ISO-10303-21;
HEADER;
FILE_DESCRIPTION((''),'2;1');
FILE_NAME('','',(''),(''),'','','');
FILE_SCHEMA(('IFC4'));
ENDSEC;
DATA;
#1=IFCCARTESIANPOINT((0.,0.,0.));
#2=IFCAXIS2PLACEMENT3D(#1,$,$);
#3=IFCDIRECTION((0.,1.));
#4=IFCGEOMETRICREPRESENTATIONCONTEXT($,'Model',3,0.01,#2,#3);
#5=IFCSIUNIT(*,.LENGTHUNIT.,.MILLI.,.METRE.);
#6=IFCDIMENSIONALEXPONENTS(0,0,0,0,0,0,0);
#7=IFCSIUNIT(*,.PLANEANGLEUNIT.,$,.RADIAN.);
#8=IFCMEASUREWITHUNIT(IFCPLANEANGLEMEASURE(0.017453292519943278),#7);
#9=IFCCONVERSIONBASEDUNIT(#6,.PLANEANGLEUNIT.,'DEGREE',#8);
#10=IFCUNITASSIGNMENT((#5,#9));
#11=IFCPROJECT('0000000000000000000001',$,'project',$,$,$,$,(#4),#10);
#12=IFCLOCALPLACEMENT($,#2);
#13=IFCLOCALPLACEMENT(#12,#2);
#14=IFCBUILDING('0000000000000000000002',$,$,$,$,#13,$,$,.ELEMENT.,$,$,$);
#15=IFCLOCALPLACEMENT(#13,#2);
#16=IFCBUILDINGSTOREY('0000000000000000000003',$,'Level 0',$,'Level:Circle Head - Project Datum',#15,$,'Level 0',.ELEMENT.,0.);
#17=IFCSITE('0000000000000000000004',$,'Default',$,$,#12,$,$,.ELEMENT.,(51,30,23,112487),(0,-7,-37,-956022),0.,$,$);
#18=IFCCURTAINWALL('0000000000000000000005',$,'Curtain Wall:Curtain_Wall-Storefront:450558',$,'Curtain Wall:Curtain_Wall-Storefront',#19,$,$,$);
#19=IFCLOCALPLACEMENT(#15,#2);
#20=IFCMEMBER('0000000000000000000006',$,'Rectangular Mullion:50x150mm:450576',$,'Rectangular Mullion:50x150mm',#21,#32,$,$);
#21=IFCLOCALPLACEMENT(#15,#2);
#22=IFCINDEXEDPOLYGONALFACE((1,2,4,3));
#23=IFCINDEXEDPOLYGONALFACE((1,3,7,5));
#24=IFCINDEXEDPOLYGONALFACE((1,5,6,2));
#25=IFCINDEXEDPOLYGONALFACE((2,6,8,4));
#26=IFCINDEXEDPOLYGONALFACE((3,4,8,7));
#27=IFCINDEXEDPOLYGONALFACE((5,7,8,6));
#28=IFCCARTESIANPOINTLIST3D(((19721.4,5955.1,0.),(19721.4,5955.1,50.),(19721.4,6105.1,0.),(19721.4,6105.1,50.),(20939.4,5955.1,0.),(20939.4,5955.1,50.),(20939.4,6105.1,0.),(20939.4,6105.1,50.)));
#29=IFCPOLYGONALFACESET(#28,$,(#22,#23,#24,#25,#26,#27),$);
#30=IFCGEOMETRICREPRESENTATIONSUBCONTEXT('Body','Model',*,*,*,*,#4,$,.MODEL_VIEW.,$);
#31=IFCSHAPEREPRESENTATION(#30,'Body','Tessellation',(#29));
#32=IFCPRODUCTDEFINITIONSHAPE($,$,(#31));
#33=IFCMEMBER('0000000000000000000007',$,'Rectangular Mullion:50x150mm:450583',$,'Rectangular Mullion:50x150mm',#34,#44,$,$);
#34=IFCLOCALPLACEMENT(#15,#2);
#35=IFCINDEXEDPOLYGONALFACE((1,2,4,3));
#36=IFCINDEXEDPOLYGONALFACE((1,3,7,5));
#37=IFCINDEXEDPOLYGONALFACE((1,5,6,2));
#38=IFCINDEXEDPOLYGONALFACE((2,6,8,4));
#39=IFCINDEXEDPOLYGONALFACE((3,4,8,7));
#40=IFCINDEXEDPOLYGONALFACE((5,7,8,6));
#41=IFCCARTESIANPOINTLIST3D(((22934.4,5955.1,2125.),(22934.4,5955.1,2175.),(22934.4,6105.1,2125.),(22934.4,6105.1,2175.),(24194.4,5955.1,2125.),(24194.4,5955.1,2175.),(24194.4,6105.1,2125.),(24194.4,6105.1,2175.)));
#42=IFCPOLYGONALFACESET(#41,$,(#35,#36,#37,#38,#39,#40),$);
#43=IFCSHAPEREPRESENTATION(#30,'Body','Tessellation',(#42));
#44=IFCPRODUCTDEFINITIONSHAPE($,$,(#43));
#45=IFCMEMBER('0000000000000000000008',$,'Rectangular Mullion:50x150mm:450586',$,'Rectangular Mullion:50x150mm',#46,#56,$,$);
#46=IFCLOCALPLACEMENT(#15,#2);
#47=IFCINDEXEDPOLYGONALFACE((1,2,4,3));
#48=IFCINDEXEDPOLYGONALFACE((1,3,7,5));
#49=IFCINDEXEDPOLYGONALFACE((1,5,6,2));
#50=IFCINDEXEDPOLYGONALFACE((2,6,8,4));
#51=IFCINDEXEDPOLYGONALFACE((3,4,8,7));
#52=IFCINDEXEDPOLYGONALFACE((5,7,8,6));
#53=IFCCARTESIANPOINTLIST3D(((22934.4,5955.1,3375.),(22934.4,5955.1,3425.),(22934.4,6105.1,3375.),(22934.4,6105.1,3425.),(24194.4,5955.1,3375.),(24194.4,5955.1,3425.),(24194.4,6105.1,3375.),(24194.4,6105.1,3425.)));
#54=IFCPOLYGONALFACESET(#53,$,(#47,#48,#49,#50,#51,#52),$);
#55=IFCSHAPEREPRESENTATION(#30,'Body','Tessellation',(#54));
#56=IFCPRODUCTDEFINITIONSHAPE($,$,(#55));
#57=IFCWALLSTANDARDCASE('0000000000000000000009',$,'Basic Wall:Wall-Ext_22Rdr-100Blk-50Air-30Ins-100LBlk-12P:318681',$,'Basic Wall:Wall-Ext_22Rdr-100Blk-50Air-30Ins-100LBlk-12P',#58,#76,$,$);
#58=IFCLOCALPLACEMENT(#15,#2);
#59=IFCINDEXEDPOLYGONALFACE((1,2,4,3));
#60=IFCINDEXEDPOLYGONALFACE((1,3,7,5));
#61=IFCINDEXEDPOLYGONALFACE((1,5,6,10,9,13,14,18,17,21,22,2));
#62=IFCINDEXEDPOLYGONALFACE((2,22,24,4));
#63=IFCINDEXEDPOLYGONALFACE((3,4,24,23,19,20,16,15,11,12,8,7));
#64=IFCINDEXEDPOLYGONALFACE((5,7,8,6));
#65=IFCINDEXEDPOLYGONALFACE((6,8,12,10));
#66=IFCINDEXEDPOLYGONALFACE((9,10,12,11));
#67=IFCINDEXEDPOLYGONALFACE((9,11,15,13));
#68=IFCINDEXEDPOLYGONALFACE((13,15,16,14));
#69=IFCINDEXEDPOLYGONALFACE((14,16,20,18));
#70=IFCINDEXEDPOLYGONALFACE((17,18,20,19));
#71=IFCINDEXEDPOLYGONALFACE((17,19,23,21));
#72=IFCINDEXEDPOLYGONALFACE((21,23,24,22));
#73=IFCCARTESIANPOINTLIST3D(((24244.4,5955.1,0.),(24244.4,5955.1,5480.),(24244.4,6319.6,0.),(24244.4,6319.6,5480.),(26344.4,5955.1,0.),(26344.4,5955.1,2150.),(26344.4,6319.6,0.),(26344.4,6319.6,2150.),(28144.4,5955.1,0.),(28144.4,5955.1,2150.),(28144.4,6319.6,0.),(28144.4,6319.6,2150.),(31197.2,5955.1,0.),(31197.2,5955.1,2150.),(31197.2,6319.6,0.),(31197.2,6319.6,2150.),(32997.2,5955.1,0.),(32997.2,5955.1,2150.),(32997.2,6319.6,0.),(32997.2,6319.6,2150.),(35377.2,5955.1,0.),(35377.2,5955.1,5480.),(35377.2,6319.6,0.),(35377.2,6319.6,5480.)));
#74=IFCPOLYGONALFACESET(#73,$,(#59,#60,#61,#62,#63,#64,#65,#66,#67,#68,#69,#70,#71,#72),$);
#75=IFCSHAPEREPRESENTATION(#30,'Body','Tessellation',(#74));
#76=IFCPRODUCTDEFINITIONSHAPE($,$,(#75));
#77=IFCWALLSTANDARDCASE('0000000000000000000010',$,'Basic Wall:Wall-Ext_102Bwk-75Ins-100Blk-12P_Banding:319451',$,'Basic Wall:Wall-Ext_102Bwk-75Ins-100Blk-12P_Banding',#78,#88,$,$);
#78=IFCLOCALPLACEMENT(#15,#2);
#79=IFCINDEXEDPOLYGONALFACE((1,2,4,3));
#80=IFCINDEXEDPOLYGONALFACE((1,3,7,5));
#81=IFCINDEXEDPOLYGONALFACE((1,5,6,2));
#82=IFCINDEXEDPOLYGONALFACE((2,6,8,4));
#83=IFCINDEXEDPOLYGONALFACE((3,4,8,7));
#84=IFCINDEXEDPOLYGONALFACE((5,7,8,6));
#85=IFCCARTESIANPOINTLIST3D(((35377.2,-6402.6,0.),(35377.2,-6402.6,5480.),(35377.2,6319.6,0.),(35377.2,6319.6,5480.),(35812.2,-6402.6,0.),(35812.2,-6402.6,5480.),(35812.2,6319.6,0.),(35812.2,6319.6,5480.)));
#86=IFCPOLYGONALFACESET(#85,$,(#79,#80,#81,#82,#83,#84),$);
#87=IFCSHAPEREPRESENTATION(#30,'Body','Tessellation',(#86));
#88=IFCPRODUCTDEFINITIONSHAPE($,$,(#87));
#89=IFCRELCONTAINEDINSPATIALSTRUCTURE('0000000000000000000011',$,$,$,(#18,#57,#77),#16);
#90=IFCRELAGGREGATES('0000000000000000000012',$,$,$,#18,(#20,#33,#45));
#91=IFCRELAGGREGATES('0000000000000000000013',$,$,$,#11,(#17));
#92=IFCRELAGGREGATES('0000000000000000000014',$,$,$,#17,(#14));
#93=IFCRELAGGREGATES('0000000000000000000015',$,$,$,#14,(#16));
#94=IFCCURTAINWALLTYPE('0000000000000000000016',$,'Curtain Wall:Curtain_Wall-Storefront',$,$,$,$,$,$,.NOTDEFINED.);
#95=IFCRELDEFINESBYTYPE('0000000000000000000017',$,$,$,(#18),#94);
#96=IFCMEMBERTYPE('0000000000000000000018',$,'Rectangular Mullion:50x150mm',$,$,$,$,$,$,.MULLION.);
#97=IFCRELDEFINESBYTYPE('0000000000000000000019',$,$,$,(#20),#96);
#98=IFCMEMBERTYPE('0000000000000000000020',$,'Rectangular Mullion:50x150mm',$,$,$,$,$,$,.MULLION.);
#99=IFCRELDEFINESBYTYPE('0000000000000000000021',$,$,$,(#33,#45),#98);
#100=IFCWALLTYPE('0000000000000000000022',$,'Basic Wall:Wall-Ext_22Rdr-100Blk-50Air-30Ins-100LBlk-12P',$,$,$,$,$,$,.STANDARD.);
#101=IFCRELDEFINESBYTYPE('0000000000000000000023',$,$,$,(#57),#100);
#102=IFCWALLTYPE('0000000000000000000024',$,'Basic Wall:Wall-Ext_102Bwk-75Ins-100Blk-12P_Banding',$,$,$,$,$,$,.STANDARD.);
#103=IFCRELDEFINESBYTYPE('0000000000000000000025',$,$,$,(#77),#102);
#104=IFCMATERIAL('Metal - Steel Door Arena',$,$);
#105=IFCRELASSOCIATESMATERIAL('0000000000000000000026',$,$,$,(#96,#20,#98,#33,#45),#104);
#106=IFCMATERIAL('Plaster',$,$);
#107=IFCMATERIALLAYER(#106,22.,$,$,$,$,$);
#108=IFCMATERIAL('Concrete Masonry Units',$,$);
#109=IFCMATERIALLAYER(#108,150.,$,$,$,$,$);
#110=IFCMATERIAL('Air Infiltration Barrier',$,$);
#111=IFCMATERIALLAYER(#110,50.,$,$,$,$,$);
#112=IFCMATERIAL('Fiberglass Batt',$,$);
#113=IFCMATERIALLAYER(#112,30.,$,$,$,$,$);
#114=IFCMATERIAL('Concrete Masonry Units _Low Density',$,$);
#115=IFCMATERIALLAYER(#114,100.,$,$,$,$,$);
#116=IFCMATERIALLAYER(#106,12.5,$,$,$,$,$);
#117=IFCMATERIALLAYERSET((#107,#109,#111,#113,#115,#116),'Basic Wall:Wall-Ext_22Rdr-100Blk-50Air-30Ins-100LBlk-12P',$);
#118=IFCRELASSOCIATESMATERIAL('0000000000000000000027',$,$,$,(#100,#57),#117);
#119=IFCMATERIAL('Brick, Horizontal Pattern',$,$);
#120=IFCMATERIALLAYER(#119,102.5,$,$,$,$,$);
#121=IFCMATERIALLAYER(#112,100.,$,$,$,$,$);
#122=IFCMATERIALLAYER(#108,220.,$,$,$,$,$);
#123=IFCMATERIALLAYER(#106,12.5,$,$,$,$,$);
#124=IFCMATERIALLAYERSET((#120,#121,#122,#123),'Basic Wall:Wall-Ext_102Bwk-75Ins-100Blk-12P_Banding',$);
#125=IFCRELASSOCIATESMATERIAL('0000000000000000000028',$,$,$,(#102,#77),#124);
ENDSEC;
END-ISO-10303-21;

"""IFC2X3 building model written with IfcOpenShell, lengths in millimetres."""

from ifc_helpers import new_model, entity, si_unit, converted_unit, direction, frame, frame_2d, origin, origin_2d_with_axis, place, context, subcontext, project, spatial, rectangle, extrude, source, transform, mapped, material, layer, layer_set, layer_usage, type_object, type_shapes, element, aggregate, save


model = new_model("IFC2X3")

# Units and contexts
model_context = context("Model", 3, precision=0.01, world=origin(), true_north=direction((0.0, 1.0)))
body_context = subcontext(model_context, "Body", "Model", "MODEL_VIEW")
ifc_project = project(units=[si_unit("LENGTHUNIT", "METRE", prefix="MILLI"), converted_unit("PLANEANGLEUNIT", "DEGREE", entity("IfcPlaneAngleMeasure", 0.017453292519943278), si_unit("PLANEANGLEUNIT", "RADIAN"), dimensions=[0, 0, 0, 0, 0, 0, 0])], contexts=[model_context])

# Site, building, storey
site_placement = place(None, origin())
site = spatial("IfcSite", under=ifc_project, at=site_placement, Name="Default", CompositionType="ELEMENT", RefLatitude=(51, 30, 23, 112487), RefLongitude=(0, -7, -37, -956022), RefElevation=0.0)
building_placement = place(site_placement, origin())
building = spatial("IfcBuilding", under=site, at=building_placement, CompositionType="ELEMENT")
storey_placement = place(building_placement, origin())
storey = spatial("IfcBuildingStorey", under=building, at=storey_placement, Name="Level 0", ObjectType="Level:Circle Head - Project Datum", LongName="Level 0", CompositionType="ELEMENT", Elevation=0.0)

# Curtain wall, members
curtain_wall_type = type_object("IfcCurtainWallType", Name="Curtain Wall:Curtain_Wall-Storefront", PredefinedType="NOTDEFINED")
curtain_wall_placement = place(storey_placement, origin())
curtain_wall = element("IfcCurtainWall", 1, at=curtain_wall_placement, inside=storey, type_object=curtain_wall_type, Name="Curtain Wall:Curtain_Wall-Storefront:450558", ObjectType="Curtain Wall:Curtain_Wall-Storefront")
ifc_material_1 = material(Name="Metal - Steel Door Arena")
member_type_1 = type_object("IfcMemberType", Name="Rectangular Mullion:50x150mm", PredefinedType="MULLION", material=ifc_material_1)
shared_shape_1 = source(origin(), body_context, "Body", "SweptSolid", [
    extrude(rectangle(XDim=50.0, YDim=150.0, at=origin_2d_with_axis()), frame((-25.0, 0.0, -1218.0), z_axis=(0.0, 0.0, 1.0), x_axis=(-1.0, 0.0, 0.0)), (0.0, 0.0, 1.0), 1218.0),
])
type_shapes(member_type_1, [shared_shape_1])
member_1_placement = place(curtain_wall_placement, frame((20939.4, 6030.1, 0.0), z_axis=(1.0, 0.0, 0.0), x_axis=(0.0, 0.0, -1.0)))
member_1 = element("IfcMember", 2, at=member_1_placement, type_object=member_type_1, material=ifc_material_1, Name="Rectangular Mullion:50x150mm:450576", ObjectType="Rectangular Mullion:50x150mm", context=body_context, shape_type="MappedRepresentation", body=[
    mapped(shared_shape_1, transform((0.0, 0.0, 0.0), scale=1.0)),
])
member_type_2 = type_object("IfcMemberType", Name="Rectangular Mullion:50x150mm", PredefinedType="MULLION", material=ifc_material_1)
shared_shape_2 = source(origin(), body_context, "Body", "SweptSolid", [
    extrude(rectangle(XDim=50.0, YDim=150.0, at=origin_2d_with_axis()), frame((0.0, 0.0, -1260.0), z_axis=(0.0, 0.0, 1.0), x_axis=(-1.0, 0.0, 0.0)), (0.0, 0.0, 1.0), 1260.0),
])
type_shapes(member_type_2, [shared_shape_2])
member_2_placement = place(curtain_wall_placement, frame((22934.4, 6030.1, 2150.0), z_axis=(-1.0, 0.0, 0.0), x_axis=(0.0, 0.0, 1.0)))
member_2 = element("IfcMember", 3, at=member_2_placement, type_object=member_type_2, material=ifc_material_1, Name="Rectangular Mullion:50x150mm:450583", ObjectType="Rectangular Mullion:50x150mm", context=body_context, shape_type="MappedRepresentation", body=[
    mapped(shared_shape_2, transform((0.0, 0.0, 0.0), scale=1.0)),
])
member_3_placement = place(curtain_wall_placement, frame((22934.4, 6030.1, 3400.0), z_axis=(-1.0, 0.0, 0.0), x_axis=(0.0, 0.0, 1.0)))
member_3 = element("IfcMember", 4, at=member_3_placement, type_object=member_type_2, material=ifc_material_1, Name="Rectangular Mullion:50x150mm:450586", ObjectType="Rectangular Mullion:50x150mm", context=body_context, shape_type="MappedRepresentation", body=[
    mapped(shared_shape_2, transform((0.0, 0.0, 0.0), scale=1.0)),
])
aggregate(curtain_wall, [member_1, member_2, member_3])

# Wall, openings
ifc_material_2 = material(Name="Plaster")
ifc_layer_1 = layer(ifc_material_2, 22.0)
ifc_material_3 = material(Name="Concrete Masonry Units")
ifc_layer_2 = layer(ifc_material_3, 150.0)
ifc_material_4 = material(Name="Air Infiltration Barrier")
ifc_layer_3 = layer(ifc_material_4, 50.0)
ifc_material_5 = material(Name="Fiberglass Batt")
ifc_layer_4 = layer(ifc_material_5, 30.0)
ifc_material_6 = material(Name="Concrete Masonry Units _Low Density")
ifc_layer_5 = layer(ifc_material_6, 100.0)
ifc_layer_6 = layer(ifc_material_2, 12.5)
ifc_layer_set_1 = layer_set([ifc_layer_1, ifc_layer_2, ifc_layer_3, ifc_layer_4, ifc_layer_5, ifc_layer_6], Name="Basic Wall:Wall-Ext_22Rdr-100Blk-50Air-30Ins-100LBlk-12P")
ifc_layer_usage_1 = layer_usage(ifc_layer_set_1, "AXIS2", "NEGATIVE", 182.3)
wall_type_1 = type_object("IfcWallType", Name="Basic Wall:Wall-Ext_22Rdr-100Blk-50Air-30Ins-100LBlk-12P", PredefinedType="STANDARD", material=ifc_layer_set_1)
wall_1_placement = place(storey_placement, frame((35377.2, 6137.4, 0.0), z_axis=(0.0, 0.0, 1.0), x_axis=(-1.0, 0.0, 0.0)))
wall_1 = element("IfcWallStandardCase", 5, at=wall_1_placement, inside=storey, type_object=wall_type_1, material=ifc_layer_usage_1, Name="Basic Wall:Wall-Ext_22Rdr-100Blk-50Air-30Ins-100LBlk-12P:318681", ObjectType="Basic Wall:Wall-Ext_22Rdr-100Blk-50Air-30Ins-100LBlk-12P", context=body_context, shape_type="SweptSolid", body=[
    extrude(rectangle(XDim=11132.8, YDim=364.5, at=frame_2d((5566.4, 0.0), x_axis=(1.0, 0.0))), origin(), (0.0, 0.0, 1.0), 5480.0),
])
opening_1_placement = place(wall_1_placement, frame((9032.7, 182.2, 0.0)))
element("IfcOpeningElement", 6, at=opening_1_placement, cuts=wall_1, ObjectType="Opening", context=body_context, shape_type="SweptSolid", body=[
    extrude(rectangle(XDim=2150.0, YDim=1800.0, at=frame_2d((1075.0, 900.0), x_axis=(1.0, 0.0))), frame((0.0, 0.0, 0.0), z_axis=(0.0, -1.0, 0.0), x_axis=(0.0, 0.0, 1.0)), (0.0, 0.0, 1.0), 364.5),
])
opening_2_placement = place(wall_1_placement, frame((4180.0, 182.2, 0.0)))
element("IfcOpeningElement", 7, at=opening_2_placement, cuts=wall_1, ObjectType="Opening", context=body_context, shape_type="SweptSolid", body=[
    extrude(rectangle(XDim=2150.0, YDim=1800.0, at=frame_2d((1075.0, 900.0), x_axis=(1.0, 0.0))), frame((0.0, 0.0, 0.0), z_axis=(0.0, -1.0, 0.0), x_axis=(0.0, 0.0, 1.0)), (0.0, 0.0, 1.0), 364.5),
])

# Wall
ifc_material_7 = material(Name="Brick, Horizontal Pattern")
ifc_layer_7 = layer(ifc_material_7, 102.5)
ifc_layer_8 = layer(ifc_material_5, 100.0)
ifc_layer_9 = layer(ifc_material_3, 220.0)
ifc_layer_10 = layer(ifc_material_2, 12.5)
ifc_layer_set_2 = layer_set([ifc_layer_7, ifc_layer_8, ifc_layer_9, ifc_layer_10], Name="Basic Wall:Wall-Ext_102Bwk-75Ins-100Blk-12P_Banding")
ifc_layer_usage_2 = layer_usage(ifc_layer_set_2, "AXIS2", "NEGATIVE", 217.5)
wall_type_2 = type_object("IfcWallType", Name="Basic Wall:Wall-Ext_102Bwk-75Ins-100Blk-12P_Banding", PredefinedType="STANDARD", material=ifc_layer_set_2)
wall_2_placement = place(storey_placement, frame((35594.7, 6319.6, 0.0), z_axis=(0.0, 0.0, 1.0), x_axis=(0.0, -1.0, 0.0)))
element("IfcWallStandardCase", 8, at=wall_2_placement, inside=storey, type_object=wall_type_2, material=ifc_layer_usage_2, Name="Basic Wall:Wall-Ext_102Bwk-75Ins-100Blk-12P_Banding:319451", ObjectType="Basic Wall:Wall-Ext_102Bwk-75Ins-100Blk-12P_Banding", context=body_context, shape_type="SweptSolid", body=[
    extrude(rectangle(XDim=12722.3, YDim=435.0, at=frame_2d((6361.1, 0.0), x_axis=(-1.0, 0.0))), origin(), (0.0, 0.0, 1.0), 5480.0),
])

save(model, "model.ifc")
